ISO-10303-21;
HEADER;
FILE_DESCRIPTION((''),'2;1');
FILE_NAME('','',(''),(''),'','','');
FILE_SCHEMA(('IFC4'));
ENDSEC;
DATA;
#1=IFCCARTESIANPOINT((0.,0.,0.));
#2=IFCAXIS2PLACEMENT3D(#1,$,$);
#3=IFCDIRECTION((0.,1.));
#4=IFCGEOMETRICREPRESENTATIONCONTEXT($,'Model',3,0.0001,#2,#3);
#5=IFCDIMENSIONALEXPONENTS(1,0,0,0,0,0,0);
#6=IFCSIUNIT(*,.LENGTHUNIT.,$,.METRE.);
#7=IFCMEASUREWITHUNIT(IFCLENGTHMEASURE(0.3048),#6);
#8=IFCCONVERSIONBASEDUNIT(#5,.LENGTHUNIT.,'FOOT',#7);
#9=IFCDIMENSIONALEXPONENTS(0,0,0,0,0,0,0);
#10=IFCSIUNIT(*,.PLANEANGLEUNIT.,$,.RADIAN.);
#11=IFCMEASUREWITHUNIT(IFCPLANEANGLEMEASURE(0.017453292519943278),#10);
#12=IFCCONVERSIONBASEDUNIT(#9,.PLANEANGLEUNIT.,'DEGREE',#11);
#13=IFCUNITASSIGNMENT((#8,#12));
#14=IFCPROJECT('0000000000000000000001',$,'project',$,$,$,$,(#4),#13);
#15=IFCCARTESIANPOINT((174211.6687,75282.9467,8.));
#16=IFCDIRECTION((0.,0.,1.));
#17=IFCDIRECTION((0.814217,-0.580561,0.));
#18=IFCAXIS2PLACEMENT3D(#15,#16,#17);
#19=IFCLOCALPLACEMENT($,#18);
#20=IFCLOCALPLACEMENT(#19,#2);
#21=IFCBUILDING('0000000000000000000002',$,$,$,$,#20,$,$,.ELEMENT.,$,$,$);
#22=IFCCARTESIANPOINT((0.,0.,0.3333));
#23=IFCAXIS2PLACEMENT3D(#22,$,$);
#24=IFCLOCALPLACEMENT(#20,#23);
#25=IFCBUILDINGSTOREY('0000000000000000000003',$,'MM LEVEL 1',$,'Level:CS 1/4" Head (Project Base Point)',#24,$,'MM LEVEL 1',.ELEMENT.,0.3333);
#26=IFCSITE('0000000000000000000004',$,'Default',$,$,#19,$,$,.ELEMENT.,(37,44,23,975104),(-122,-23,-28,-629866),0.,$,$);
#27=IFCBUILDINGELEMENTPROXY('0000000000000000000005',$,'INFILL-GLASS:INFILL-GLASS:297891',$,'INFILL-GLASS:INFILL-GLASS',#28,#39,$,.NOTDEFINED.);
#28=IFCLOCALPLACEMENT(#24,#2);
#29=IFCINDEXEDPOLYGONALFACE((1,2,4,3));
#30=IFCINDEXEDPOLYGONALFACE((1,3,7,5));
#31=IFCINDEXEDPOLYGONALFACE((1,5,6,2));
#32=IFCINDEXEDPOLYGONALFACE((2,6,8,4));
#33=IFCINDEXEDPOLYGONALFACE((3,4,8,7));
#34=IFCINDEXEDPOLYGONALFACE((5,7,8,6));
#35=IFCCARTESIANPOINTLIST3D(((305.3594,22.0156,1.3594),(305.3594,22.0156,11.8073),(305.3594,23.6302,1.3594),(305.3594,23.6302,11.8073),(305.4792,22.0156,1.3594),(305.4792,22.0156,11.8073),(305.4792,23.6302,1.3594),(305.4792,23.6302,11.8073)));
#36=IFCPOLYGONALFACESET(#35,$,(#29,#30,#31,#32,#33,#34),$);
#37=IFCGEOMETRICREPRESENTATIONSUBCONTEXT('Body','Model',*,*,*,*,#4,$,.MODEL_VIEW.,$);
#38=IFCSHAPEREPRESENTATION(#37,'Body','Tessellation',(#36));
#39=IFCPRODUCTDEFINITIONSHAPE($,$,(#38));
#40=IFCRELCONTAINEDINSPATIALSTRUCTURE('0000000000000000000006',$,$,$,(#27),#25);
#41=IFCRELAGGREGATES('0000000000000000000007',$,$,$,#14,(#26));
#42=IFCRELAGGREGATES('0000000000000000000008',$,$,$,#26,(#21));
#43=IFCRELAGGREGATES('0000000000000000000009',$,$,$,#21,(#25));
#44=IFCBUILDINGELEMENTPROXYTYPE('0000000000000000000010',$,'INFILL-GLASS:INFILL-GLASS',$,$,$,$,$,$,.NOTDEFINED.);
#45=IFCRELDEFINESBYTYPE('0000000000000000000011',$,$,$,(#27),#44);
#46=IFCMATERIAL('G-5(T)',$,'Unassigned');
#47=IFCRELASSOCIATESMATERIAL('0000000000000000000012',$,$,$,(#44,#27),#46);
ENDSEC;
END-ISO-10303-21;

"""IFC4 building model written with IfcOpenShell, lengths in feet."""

from ifc_helpers import new_model, entity, si_unit, converted_unit, direction, frame, origin, place, context, subcontext, project, spatial, indexed_curve, outline, extrude, source, transform, mapped, material, type_object, type_shapes, element, save


model = new_model("IFC4")

# Units and contexts
model_context = context("Model", 3, precision=0.0001, world=origin(), true_north=direction((0.0, 1.0)))
body_context = subcontext(model_context, "Body", "Model", "MODEL_VIEW")
ifc_project = project(units=[converted_unit("LENGTHUNIT", "FOOT", entity("IfcLengthMeasure", 0.3048), si_unit("LENGTHUNIT", "METRE"), dimensions=[1, 0, 0, 0, 0, 0, 0]), converted_unit("PLANEANGLEUNIT", "DEGREE", entity("IfcPlaneAngleMeasure", 0.017453292519943278), si_unit("PLANEANGLEUNIT", "RADIAN"), dimensions=[0, 0, 0, 0, 0, 0, 0])], contexts=[model_context])

# Site, building, storey
site_placement = place(None, frame((174211.6687, 75282.9467, 8.0), z_axis=(0.0, 0.0, 1.0), x_axis=(0.814217, -0.580561, 0.0)))
site = spatial("IfcSite", under=ifc_project, at=site_placement, Name="Default", CompositionType="ELEMENT", RefLatitude=(37, 44, 23, 975104), RefLongitude=(-122, -23, -28, -629866), RefElevation=0.0)
building_placement = place(site_placement, origin())
building = spatial("IfcBuilding", under=site, at=building_placement, CompositionType="ELEMENT")
storey_placement = place(building_placement, frame((0.0, 0.0, 0.3333)))
storey = spatial("IfcBuildingStorey", under=building, at=storey_placement, Name="MM LEVEL 1", ObjectType="Level:CS 1/4\" Head (Project Base Point)", LongName="MM LEVEL 1", CompositionType="ELEMENT", Elevation=0.3333)

# Building element proxy
ifc_material_1 = material(Name="G-5(T)", Category="Unassigned")
building_element_proxy_type_1 = type_object("IfcBuildingElementProxyType", Name="INFILL-GLASS:INFILL-GLASS", PredefinedType="NOTDEFINED", material=ifc_material_1)
shared_shape_1 = source(origin(), body_context, "Body", "SweptSolid", [
    extrude(outline(indexed_curve([(-0.0599, -0.8073), (0.0599, -0.8073), (0.0599, 0.8073), (-0.0599, 0.8073), (-0.0599, -0.8073)], self_intersect=False)), frame((0.0, 0.1016, 0.1302), z_axis=(0.0, 0.0, 1.0), x_axis=(0.0, 1.0, 0.0)), (0.0, 0.0, 1.0), 10.4479),
])
type_shapes(building_element_proxy_type_1, [shared_shape_1])
for number, where, z_axis, x_axis, name in (
    (1, (305.5208, 22.8229, 1.2292), (0.0, 0.0, 1.0), (0.0, 1.0, 0.0), "INFILL-GLASS:INFILL-GLASS:297891"),
):
    element("IfcBuildingElementProxy", number, at=place(storey_placement, frame(where, z_axis=z_axis, x_axis=x_axis)), inside=storey, type_object=building_element_proxy_type_1, material=ifc_material_1, Name=name, ObjectType="INFILL-GLASS:INFILL-GLASS", PredefinedType="NOTDEFINED", context=body_context, shape_type="MappedRepresentation", body=[
        mapped(shared_shape_1, transform((0.0, 0.0, 0.0), scale=1.0)),
    ])

save(model, "model.ifc")
